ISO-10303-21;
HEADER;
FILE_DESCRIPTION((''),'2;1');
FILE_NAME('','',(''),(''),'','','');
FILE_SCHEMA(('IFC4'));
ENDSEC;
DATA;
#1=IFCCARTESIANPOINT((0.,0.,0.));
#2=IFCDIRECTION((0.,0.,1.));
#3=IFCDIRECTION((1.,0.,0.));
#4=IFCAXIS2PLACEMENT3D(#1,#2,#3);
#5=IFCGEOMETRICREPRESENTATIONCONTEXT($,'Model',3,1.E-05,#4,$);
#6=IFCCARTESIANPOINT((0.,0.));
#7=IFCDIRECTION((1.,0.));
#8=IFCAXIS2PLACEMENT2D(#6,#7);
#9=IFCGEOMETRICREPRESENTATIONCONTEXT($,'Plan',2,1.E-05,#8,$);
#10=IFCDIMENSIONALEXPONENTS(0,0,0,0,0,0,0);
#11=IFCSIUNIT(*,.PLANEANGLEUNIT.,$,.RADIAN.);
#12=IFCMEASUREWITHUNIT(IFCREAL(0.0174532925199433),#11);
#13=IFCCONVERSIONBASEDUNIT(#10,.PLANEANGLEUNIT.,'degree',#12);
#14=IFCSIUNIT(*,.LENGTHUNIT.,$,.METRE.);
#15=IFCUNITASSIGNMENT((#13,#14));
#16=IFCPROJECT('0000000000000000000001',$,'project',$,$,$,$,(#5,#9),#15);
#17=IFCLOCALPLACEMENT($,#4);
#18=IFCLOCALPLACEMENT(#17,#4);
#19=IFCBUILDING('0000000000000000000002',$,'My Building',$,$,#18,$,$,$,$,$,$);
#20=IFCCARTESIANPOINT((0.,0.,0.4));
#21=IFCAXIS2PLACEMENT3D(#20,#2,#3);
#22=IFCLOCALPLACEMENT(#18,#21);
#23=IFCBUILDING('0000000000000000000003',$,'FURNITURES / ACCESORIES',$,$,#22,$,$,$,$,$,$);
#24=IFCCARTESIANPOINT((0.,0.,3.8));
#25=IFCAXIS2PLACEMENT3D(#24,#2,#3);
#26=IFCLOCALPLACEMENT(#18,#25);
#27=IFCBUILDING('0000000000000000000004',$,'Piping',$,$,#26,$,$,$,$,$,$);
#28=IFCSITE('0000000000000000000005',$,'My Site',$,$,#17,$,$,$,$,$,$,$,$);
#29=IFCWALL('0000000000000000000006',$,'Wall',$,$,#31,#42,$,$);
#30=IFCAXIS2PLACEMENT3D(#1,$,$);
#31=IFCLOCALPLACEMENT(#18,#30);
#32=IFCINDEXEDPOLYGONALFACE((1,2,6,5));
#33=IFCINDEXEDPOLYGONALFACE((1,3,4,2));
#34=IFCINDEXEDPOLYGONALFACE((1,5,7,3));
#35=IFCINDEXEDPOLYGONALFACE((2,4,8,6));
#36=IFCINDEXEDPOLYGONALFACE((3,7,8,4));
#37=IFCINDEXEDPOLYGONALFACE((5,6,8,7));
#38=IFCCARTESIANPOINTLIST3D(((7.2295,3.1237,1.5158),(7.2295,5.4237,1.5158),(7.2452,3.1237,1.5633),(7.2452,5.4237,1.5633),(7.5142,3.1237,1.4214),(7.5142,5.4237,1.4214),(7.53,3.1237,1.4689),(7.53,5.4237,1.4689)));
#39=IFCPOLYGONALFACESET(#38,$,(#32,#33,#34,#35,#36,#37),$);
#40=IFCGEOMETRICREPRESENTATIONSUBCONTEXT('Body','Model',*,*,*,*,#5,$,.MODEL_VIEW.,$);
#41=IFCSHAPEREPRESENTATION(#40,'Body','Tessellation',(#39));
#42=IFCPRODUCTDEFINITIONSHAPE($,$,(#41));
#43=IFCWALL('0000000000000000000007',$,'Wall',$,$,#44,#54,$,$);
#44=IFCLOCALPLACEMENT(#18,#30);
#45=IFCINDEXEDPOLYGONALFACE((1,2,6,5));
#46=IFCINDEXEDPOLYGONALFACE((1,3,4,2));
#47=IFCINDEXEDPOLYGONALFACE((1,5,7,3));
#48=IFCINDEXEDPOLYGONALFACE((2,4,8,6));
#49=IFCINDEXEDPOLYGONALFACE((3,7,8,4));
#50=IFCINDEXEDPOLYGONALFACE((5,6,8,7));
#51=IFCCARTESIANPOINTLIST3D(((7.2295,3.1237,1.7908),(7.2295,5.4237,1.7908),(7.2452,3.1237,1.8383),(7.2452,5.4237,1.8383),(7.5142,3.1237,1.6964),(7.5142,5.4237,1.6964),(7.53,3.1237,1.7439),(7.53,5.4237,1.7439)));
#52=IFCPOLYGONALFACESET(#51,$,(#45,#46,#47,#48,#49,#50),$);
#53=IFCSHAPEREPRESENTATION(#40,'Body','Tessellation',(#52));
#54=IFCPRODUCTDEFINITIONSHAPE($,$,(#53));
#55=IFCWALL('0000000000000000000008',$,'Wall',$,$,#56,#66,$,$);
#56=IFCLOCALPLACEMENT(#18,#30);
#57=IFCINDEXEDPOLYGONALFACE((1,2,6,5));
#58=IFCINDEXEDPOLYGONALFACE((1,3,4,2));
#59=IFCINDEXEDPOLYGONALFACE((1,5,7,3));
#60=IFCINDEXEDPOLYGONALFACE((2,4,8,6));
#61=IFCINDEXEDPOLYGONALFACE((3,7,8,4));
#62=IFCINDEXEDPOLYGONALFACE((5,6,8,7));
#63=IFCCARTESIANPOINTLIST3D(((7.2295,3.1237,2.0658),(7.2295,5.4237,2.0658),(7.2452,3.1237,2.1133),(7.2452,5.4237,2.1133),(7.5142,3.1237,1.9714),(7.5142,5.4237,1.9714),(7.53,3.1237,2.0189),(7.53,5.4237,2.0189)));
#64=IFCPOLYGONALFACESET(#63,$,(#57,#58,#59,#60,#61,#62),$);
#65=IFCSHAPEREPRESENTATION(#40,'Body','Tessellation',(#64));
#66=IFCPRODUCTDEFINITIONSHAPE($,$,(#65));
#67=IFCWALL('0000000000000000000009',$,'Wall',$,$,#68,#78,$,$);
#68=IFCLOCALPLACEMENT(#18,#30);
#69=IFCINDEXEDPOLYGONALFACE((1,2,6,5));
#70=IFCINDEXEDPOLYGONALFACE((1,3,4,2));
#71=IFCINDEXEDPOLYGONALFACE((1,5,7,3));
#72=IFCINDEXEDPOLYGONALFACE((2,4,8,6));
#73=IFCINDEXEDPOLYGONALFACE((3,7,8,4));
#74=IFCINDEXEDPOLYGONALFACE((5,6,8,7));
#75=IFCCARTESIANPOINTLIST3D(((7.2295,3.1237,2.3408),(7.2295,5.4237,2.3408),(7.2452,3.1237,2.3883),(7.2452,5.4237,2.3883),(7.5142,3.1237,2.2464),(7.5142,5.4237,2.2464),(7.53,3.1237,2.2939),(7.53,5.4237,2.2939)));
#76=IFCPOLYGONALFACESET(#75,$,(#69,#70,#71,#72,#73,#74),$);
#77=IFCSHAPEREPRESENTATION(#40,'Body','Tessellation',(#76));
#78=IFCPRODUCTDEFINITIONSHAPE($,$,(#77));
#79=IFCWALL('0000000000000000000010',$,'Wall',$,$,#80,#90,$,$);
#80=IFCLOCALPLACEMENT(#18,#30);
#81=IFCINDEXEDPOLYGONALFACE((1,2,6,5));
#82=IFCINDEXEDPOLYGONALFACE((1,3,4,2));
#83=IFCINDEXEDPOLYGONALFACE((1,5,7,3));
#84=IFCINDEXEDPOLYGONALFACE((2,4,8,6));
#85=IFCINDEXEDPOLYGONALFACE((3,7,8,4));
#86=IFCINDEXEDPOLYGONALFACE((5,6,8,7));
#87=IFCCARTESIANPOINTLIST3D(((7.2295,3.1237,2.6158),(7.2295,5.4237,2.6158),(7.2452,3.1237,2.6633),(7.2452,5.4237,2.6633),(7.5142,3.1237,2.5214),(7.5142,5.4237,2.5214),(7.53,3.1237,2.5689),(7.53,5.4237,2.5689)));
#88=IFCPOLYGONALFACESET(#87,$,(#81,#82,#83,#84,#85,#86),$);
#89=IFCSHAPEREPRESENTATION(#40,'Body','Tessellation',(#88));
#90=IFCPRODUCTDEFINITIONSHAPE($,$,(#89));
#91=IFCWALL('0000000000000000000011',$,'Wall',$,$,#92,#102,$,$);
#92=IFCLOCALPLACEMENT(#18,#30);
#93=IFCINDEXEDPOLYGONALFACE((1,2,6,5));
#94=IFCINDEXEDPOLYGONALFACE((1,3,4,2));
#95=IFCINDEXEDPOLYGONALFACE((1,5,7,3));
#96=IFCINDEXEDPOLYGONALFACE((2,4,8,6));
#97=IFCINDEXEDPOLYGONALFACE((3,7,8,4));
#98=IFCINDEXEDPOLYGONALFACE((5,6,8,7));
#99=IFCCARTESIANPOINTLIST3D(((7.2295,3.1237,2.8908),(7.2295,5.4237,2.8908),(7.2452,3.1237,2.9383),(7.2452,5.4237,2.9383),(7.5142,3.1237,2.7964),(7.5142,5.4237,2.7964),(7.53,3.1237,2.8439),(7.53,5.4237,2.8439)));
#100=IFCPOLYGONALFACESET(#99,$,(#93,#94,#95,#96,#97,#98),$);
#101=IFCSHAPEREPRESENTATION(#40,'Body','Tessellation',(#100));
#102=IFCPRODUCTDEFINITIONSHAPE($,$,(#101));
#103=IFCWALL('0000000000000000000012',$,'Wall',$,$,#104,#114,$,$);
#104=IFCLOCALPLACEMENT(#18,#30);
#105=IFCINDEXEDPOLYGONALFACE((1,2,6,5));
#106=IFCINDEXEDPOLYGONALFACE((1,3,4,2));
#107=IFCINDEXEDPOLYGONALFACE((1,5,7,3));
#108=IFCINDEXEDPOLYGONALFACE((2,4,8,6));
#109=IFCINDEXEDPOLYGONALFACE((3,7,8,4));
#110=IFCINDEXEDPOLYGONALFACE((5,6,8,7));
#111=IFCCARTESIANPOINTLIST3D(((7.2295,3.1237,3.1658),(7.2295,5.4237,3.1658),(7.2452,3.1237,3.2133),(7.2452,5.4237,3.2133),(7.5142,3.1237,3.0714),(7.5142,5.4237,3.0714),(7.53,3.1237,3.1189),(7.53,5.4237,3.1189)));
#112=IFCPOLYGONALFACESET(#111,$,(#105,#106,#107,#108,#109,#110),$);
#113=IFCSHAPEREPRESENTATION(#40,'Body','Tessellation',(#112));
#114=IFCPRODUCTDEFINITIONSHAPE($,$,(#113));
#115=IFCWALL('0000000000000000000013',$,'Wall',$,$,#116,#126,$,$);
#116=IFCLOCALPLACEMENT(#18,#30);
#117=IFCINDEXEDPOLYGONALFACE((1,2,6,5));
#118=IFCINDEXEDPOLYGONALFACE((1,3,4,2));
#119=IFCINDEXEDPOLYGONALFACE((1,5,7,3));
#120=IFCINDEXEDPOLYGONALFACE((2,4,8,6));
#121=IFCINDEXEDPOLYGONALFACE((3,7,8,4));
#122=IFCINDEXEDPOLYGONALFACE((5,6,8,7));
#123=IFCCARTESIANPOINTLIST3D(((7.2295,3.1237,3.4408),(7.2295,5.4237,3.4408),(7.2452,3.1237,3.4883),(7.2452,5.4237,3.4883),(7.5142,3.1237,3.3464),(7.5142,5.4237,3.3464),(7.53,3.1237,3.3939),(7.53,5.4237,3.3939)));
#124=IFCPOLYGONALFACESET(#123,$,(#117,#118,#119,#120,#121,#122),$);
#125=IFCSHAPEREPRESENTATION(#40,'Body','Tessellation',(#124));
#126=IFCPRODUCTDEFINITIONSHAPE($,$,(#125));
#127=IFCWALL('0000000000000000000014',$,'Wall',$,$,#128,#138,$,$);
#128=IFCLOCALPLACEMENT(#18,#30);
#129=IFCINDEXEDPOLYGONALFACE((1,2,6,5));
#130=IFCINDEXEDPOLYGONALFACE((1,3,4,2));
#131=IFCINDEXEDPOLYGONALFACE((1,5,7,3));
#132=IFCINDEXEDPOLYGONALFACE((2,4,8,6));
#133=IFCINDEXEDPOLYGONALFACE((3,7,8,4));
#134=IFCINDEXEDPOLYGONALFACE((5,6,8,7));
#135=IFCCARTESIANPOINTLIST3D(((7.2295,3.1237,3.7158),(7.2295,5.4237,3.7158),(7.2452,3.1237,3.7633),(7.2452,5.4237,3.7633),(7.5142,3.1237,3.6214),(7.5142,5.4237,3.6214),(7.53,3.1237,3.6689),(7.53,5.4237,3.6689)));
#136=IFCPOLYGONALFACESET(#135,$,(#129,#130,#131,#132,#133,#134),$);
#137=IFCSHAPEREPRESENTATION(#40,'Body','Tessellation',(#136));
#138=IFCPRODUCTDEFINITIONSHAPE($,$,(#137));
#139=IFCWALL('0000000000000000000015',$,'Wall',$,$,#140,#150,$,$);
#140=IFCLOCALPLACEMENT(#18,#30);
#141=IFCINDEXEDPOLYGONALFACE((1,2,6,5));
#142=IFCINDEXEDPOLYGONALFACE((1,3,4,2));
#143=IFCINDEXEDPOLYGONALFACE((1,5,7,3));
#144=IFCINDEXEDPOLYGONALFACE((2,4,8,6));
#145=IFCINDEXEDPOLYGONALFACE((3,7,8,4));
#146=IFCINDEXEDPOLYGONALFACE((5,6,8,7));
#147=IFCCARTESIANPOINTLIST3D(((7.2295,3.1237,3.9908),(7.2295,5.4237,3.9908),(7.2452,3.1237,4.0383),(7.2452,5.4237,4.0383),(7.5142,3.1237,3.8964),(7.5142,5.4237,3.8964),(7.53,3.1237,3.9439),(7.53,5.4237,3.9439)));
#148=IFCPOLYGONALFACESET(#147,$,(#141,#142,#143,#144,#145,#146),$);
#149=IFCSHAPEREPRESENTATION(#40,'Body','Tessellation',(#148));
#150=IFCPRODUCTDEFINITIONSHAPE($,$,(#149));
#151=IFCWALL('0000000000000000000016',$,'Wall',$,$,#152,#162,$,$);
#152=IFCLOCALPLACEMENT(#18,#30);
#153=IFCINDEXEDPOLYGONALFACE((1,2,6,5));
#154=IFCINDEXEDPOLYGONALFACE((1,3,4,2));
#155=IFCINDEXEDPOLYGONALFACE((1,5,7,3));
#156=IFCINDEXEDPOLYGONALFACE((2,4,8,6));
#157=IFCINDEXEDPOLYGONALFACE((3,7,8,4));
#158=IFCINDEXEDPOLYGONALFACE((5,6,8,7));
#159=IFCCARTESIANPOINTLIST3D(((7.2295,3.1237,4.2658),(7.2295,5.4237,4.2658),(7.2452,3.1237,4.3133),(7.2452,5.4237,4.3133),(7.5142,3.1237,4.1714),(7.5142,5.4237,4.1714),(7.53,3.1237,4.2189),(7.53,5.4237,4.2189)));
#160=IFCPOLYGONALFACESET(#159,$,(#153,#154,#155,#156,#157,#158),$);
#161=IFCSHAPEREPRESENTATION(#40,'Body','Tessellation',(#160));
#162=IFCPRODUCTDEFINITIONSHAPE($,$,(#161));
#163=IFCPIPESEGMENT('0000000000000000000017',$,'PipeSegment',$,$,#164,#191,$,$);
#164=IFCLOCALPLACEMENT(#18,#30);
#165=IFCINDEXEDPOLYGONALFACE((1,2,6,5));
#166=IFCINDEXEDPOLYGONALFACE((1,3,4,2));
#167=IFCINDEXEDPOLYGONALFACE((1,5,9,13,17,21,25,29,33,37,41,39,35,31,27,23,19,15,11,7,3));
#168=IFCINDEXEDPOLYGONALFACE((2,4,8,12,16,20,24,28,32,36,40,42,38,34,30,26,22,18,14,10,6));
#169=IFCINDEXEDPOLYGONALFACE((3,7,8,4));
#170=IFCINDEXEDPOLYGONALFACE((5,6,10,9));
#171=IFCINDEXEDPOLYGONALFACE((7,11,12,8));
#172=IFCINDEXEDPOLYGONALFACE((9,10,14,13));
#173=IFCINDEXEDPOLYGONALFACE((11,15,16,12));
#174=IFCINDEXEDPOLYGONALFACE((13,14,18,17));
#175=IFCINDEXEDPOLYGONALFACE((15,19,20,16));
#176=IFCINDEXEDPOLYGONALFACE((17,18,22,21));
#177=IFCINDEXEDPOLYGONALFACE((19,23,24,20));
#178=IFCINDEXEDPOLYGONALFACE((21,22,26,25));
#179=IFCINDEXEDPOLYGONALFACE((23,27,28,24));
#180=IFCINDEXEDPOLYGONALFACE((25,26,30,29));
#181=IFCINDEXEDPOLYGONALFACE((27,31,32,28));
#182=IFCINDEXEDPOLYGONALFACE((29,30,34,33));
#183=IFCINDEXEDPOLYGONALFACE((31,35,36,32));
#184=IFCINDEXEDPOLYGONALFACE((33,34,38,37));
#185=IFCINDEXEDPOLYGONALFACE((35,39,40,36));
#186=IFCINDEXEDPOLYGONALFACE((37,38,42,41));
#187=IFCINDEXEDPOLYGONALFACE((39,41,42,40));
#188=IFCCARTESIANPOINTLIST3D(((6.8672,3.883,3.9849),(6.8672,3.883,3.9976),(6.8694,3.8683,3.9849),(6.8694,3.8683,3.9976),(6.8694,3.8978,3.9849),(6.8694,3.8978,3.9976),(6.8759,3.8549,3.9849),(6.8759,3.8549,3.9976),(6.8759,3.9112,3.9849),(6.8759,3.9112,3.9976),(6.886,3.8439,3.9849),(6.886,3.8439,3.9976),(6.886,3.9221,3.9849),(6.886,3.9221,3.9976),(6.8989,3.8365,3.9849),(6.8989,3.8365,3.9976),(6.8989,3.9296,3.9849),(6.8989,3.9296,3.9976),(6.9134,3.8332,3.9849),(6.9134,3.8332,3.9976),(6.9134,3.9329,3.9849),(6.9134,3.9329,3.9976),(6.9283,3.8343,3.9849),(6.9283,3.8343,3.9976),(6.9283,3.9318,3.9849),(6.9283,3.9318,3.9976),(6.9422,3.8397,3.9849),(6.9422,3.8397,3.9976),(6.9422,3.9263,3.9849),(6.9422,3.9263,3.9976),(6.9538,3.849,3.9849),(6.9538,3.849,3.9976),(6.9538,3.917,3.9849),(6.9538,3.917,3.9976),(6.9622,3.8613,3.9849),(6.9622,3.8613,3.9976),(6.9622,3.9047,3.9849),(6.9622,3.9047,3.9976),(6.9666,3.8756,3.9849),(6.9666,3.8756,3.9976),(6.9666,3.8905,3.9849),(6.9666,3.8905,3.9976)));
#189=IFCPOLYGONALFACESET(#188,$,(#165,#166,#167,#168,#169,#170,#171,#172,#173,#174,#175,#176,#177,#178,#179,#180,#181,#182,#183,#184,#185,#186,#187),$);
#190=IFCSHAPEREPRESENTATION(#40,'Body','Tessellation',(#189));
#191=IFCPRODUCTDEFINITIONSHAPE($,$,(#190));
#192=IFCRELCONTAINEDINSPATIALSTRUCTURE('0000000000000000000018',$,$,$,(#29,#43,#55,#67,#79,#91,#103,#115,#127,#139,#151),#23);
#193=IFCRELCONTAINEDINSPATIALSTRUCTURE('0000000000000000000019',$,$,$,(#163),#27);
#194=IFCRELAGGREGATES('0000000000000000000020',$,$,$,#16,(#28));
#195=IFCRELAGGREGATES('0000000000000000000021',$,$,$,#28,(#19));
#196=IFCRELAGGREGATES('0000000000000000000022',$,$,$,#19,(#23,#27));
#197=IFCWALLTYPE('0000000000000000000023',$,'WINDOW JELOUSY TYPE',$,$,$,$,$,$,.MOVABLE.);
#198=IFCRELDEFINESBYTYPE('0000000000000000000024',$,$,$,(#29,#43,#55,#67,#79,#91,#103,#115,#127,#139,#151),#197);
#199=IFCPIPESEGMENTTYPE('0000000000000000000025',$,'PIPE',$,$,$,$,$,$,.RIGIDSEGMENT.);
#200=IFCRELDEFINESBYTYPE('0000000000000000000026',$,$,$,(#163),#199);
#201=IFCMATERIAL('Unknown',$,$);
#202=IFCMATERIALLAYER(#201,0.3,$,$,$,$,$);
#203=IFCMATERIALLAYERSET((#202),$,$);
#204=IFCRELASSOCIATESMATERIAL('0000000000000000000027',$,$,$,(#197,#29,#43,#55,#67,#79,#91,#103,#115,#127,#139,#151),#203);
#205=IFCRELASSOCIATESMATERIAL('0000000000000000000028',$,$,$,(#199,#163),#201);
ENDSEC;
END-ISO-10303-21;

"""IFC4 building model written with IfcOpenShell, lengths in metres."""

from ifc_helpers import new_model, entity, si_unit, converted_unit, frame, origin_with_axes, origin_2d_with_axis, place, context, subcontext, project, spatial, line, indexed_curve, circle, outline, extrude, material, layer, layer_set, layer_usage, material_profile, profile_set, profile_usage, type_object, element, save


model = new_model("IFC4")

# Units and contexts
model_context = context("Model", 3, precision=1e-05, world=origin_with_axes())
plan_context = context("Plan", 2, precision=1e-05, world=origin_2d_with_axis())
body_context = subcontext(model_context, "Body", "Model", "MODEL_VIEW")
ifc_project = project(units=[converted_unit("PLANEANGLEUNIT", "degree", entity("IfcReal", 0.0174532925199433), si_unit("PLANEANGLEUNIT", "RADIAN"), dimensions=[0, 0, 0, 0, 0, 0, 0]), si_unit("LENGTHUNIT", "METRE")], contexts=[model_context, plan_context])

# Site, building
site_placement = place(None, origin_with_axes())
site = spatial("IfcSite", under=ifc_project, at=site_placement, Name="My Site")
building_1_placement = place(site_placement, origin_with_axes())
building_1 = spatial("IfcBuilding", under=site, at=building_1_placement, Name="My Building")

# Shared definitions
ifc_material = material(Name="Unknown")

# Shared definitions
building_2_placement = place(building_1_placement, frame((0.0, 0.0, 0.4), z_axis=(0.0, 0.0, 1.0), x_axis=(1.0, 0.0, 0.0)))
building_2 = spatial("IfcBuilding", under=building_1, at=building_2_placement, Name="FURNITURES / ACCESORIES")

# Walls
ifc_layer_1 = layer(ifc_material, 0.3)
ifc_layer_set_1 = layer_set([ifc_layer_1])
wall_type_1 = type_object("IfcWallType", Name="WINDOW JELOUSY TYPE", PredefinedType="MOVABLE", material=ifc_layer_set_1)
ifc_layer_usage_1 = layer_usage(ifc_layer_set_1, "AXIS2", "POSITIVE", 0.0)
wall_1_placement = place(building_2_placement, frame((7.2295, 5.4237, 1.1158), z_axis=(0.314762, 0.0, 0.949171), x_axis=(0.0, -1.0, 0.0)))
element("IfcWall", 1, at=wall_1_placement, inside=building_2, type_object=wall_type_1, material=ifc_layer_usage_1, Name="Wall", context=body_context, shape_type="SweptSolid", body=[
    extrude(outline(indexed_curve([(0.0, 0.0), (0.0, 0.3), (2.3, 0.3), (2.3, 0.0)], segments=[line(1, 2, 3, 4, 1)])), origin_with_axes(), (0.0, 0.0, 1.0), 0.05),
])
ifc_layer_usage_2 = layer_usage(ifc_layer_set_1, "AXIS2", "POSITIVE", 0.0)
wall_2_placement = place(building_2_placement, frame((7.2295, 5.4237, 1.3908), z_axis=(0.314762, 0.0, 0.949171), x_axis=(0.0, -1.0, 0.0)))
element("IfcWall", 2, at=wall_2_placement, inside=building_2, type_object=wall_type_1, material=ifc_layer_usage_2, Name="Wall", context=body_context, shape_type="SweptSolid", body=[
    extrude(outline(indexed_curve([(0.0, 0.0), (0.0, 0.3), (2.3, 0.3), (2.3, 0.0)], segments=[line(1, 2, 3, 4, 1)])), origin_with_axes(), (0.0, 0.0, 1.0), 0.05),
])
ifc_layer_usage_3 = layer_usage(ifc_layer_set_1, "AXIS2", "POSITIVE", 0.0)
wall_3_placement = place(building_2_placement, frame((7.2295, 5.4237, 1.6658), z_axis=(0.314762, 0.0, 0.949171), x_axis=(0.0, -1.0, 0.0)))
element("IfcWall", 3, at=wall_3_placement, inside=building_2, type_object=wall_type_1, material=ifc_layer_usage_3, Name="Wall", context=body_context, shape_type="SweptSolid", body=[
    extrude(outline(indexed_curve([(0.0, 0.0), (0.0, 0.3), (2.3, 0.3), (2.3, 0.0)], segments=[line(1, 2, 3, 4, 1)])), origin_with_axes(), (0.0, 0.0, 1.0), 0.05),
])
ifc_layer_usage_4 = layer_usage(ifc_layer_set_1, "AXIS2", "POSITIVE", 0.0)
wall_4_placement = place(building_2_placement, frame((7.2295, 5.4237, 1.9408), z_axis=(0.314762, 0.0, 0.949171), x_axis=(0.0, -1.0, 0.0)))
element("IfcWall", 4, at=wall_4_placement, inside=building_2, type_object=wall_type_1, material=ifc_layer_usage_4, Name="Wall", context=body_context, shape_type="SweptSolid", body=[
    extrude(outline(indexed_curve([(0.0, 0.0), (0.0, 0.3), (2.3, 0.3), (2.3, 0.0)], segments=[line(1, 2, 3, 4, 1)])), origin_with_axes(), (0.0, 0.0, 1.0), 0.05),
])
ifc_layer_usage_5 = layer_usage(ifc_layer_set_1, "AXIS2", "POSITIVE", 0.0)
wall_5_placement = place(building_2_placement, frame((7.2295, 5.4237, 2.2158), z_axis=(0.314762, 0.0, 0.949171), x_axis=(0.0, -1.0, 0.0)))
element("IfcWall", 5, at=wall_5_placement, inside=building_2, type_object=wall_type_1, material=ifc_layer_usage_5, Name="Wall", context=body_context, shape_type="SweptSolid", body=[
    extrude(outline(indexed_curve([(0.0, 0.0), (0.0, 0.3), (2.3, 0.3), (2.3, 0.0)], segments=[line(1, 2, 3, 4, 1)])), origin_with_axes(), (0.0, 0.0, 1.0), 0.05),
])
ifc_layer_usage_6 = layer_usage(ifc_layer_set_1, "AXIS2", "POSITIVE", 0.0)
wall_6_placement = place(building_2_placement, frame((7.2295, 5.4237, 2.4908), z_axis=(0.314762, 0.0, 0.949171), x_axis=(0.0, -1.0, 0.0)))
element("IfcWall", 6, at=wall_6_placement, inside=building_2, type_object=wall_type_1, material=ifc_layer_usage_6, Name="Wall", context=body_context, shape_type="SweptSolid", body=[
    extrude(outline(indexed_curve([(0.0, 0.0), (0.0, 0.3), (2.3, 0.3), (2.3, 0.0)], segments=[line(1, 2, 3, 4, 1)])), origin_with_axes(), (0.0, 0.0, 1.0), 0.05),
])
ifc_layer_usage_7 = layer_usage(ifc_layer_set_1, "AXIS2", "POSITIVE", 0.0)
wall_7_placement = place(building_2_placement, frame((7.2295, 5.4237, 2.7658), z_axis=(0.314762, 0.0, 0.949171), x_axis=(0.0, -1.0, 0.0)))
element("IfcWall", 7, at=wall_7_placement, inside=building_2, type_object=wall_type_1, material=ifc_layer_usage_7, Name="Wall", context=body_context, shape_type="SweptSolid", body=[
    extrude(outline(indexed_curve([(0.0, 0.0), (0.0, 0.3), (2.3, 0.3), (2.3, 0.0)], segments=[line(1, 2, 3, 4, 1)])), origin_with_axes(), (0.0, 0.0, 1.0), 0.05),
])
ifc_layer_usage_8 = layer_usage(ifc_layer_set_1, "AXIS2", "POSITIVE", 0.0)
wall_8_placement = place(building_2_placement, frame((7.2295, 5.4237, 3.0408), z_axis=(0.314762, 0.0, 0.949171), x_axis=(0.0, -1.0, 0.0)))
element("IfcWall", 8, at=wall_8_placement, inside=building_2, type_object=wall_type_1, material=ifc_layer_usage_8, Name="Wall", context=body_context, shape_type="SweptSolid", body=[
    extrude(outline(indexed_curve([(0.0, 0.0), (0.0, 0.3), (2.3, 0.3), (2.3, 0.0)], segments=[line(1, 2, 3, 4, 1)])), origin_with_axes(), (0.0, 0.0, 1.0), 0.05),
])
ifc_layer_usage_9 = layer_usage(ifc_layer_set_1, "AXIS2", "POSITIVE", 0.0)
wall_9_placement = place(building_2_placement, frame((7.2295, 5.4237, 3.3158), z_axis=(0.314762, 0.0, 0.949171), x_axis=(0.0, -1.0, 0.0)))
element("IfcWall", 9, at=wall_9_placement, inside=building_2, type_object=wall_type_1, material=ifc_layer_usage_9, Name="Wall", context=body_context, shape_type="SweptSolid", body=[
    extrude(outline(indexed_curve([(0.0, 0.0), (0.0, 0.3), (2.3, 0.3), (2.3, 0.0)], segments=[line(1, 2, 3, 4, 1)])), origin_with_axes(), (0.0, 0.0, 1.0), 0.05),
])
ifc_layer_usage_10 = layer_usage(ifc_layer_set_1, "AXIS2", "POSITIVE", 0.0)
wall_10_placement = place(building_2_placement, frame((7.2295, 5.4237, 3.5908), z_axis=(0.314762, 0.0, 0.949171), x_axis=(0.0, -1.0, 0.0)))
element("IfcWall", 10, at=wall_10_placement, inside=building_2, type_object=wall_type_1, material=ifc_layer_usage_10, Name="Wall", context=body_context, shape_type="SweptSolid", body=[
    extrude(outline(indexed_curve([(0.0, 0.0), (0.0, 0.3), (2.3, 0.3), (2.3, 0.0)], segments=[line(1, 2, 3, 4, 1)])), origin_with_axes(), (0.0, 0.0, 1.0), 0.05),
])
ifc_layer_usage_11 = layer_usage(ifc_layer_set_1, "AXIS2", "POSITIVE", 0.0)
wall_11_placement = place(building_2_placement, frame((7.2295, 5.4237, 3.8658), z_axis=(0.314762, 0.0, 0.949171), x_axis=(0.0, -1.0, 0.0)))
element("IfcWall", 11, at=wall_11_placement, inside=building_2, type_object=wall_type_1, material=ifc_layer_usage_11, Name="Wall", context=body_context, shape_type="SweptSolid", body=[
    extrude(outline(indexed_curve([(0.0, 0.0), (0.0, 0.3), (2.3, 0.3), (2.3, 0.0)], segments=[line(1, 2, 3, 4, 1)])), origin_with_axes(), (0.0, 0.0, 1.0), 0.05),
])

# Shared definitions
building_3_placement = place(building_1_placement, frame((0.0, 0.0, 3.8), z_axis=(0.0, 0.0, 1.0), x_axis=(1.0, 0.0, 0.0)))
building_3 = spatial("IfcBuilding", under=building_1, at=building_3_placement, Name="Piping")

# Pipe segment
ifc_material_profile = material_profile(ifc_material, circle(Radius=0.05))
ifc_profile_set = profile_set([ifc_material_profile])
ifc_profile_usage_1 = profile_usage(ifc_profile_set, cardinal=5)
pipe_segment_type = type_object("IfcPipeSegmentType", Name="PIPE", PredefinedType="RIGIDSEGMENT", material=ifc_profile_set)
pipe_segment_1_placement = place(building_3_placement, frame((6.9172, 3.883, 0.1976), z_axis=(0.0, 0.0, -1.0), x_axis=(-1.0, 0.0, 0.0)))
element("IfcPipeSegment", 12, at=pipe_segment_1_placement, inside=building_3, type_object=pipe_segment_type, material=ifc_profile_usage_1, Name="PipeSegment", context=body_context, shape_type="SweptSolid", body=[
    extrude(circle(Radius=0.05), origin_with_axes(), (0.0, 0.0, 1.0), 0.0127),
])

save(model, "model.ifc")
